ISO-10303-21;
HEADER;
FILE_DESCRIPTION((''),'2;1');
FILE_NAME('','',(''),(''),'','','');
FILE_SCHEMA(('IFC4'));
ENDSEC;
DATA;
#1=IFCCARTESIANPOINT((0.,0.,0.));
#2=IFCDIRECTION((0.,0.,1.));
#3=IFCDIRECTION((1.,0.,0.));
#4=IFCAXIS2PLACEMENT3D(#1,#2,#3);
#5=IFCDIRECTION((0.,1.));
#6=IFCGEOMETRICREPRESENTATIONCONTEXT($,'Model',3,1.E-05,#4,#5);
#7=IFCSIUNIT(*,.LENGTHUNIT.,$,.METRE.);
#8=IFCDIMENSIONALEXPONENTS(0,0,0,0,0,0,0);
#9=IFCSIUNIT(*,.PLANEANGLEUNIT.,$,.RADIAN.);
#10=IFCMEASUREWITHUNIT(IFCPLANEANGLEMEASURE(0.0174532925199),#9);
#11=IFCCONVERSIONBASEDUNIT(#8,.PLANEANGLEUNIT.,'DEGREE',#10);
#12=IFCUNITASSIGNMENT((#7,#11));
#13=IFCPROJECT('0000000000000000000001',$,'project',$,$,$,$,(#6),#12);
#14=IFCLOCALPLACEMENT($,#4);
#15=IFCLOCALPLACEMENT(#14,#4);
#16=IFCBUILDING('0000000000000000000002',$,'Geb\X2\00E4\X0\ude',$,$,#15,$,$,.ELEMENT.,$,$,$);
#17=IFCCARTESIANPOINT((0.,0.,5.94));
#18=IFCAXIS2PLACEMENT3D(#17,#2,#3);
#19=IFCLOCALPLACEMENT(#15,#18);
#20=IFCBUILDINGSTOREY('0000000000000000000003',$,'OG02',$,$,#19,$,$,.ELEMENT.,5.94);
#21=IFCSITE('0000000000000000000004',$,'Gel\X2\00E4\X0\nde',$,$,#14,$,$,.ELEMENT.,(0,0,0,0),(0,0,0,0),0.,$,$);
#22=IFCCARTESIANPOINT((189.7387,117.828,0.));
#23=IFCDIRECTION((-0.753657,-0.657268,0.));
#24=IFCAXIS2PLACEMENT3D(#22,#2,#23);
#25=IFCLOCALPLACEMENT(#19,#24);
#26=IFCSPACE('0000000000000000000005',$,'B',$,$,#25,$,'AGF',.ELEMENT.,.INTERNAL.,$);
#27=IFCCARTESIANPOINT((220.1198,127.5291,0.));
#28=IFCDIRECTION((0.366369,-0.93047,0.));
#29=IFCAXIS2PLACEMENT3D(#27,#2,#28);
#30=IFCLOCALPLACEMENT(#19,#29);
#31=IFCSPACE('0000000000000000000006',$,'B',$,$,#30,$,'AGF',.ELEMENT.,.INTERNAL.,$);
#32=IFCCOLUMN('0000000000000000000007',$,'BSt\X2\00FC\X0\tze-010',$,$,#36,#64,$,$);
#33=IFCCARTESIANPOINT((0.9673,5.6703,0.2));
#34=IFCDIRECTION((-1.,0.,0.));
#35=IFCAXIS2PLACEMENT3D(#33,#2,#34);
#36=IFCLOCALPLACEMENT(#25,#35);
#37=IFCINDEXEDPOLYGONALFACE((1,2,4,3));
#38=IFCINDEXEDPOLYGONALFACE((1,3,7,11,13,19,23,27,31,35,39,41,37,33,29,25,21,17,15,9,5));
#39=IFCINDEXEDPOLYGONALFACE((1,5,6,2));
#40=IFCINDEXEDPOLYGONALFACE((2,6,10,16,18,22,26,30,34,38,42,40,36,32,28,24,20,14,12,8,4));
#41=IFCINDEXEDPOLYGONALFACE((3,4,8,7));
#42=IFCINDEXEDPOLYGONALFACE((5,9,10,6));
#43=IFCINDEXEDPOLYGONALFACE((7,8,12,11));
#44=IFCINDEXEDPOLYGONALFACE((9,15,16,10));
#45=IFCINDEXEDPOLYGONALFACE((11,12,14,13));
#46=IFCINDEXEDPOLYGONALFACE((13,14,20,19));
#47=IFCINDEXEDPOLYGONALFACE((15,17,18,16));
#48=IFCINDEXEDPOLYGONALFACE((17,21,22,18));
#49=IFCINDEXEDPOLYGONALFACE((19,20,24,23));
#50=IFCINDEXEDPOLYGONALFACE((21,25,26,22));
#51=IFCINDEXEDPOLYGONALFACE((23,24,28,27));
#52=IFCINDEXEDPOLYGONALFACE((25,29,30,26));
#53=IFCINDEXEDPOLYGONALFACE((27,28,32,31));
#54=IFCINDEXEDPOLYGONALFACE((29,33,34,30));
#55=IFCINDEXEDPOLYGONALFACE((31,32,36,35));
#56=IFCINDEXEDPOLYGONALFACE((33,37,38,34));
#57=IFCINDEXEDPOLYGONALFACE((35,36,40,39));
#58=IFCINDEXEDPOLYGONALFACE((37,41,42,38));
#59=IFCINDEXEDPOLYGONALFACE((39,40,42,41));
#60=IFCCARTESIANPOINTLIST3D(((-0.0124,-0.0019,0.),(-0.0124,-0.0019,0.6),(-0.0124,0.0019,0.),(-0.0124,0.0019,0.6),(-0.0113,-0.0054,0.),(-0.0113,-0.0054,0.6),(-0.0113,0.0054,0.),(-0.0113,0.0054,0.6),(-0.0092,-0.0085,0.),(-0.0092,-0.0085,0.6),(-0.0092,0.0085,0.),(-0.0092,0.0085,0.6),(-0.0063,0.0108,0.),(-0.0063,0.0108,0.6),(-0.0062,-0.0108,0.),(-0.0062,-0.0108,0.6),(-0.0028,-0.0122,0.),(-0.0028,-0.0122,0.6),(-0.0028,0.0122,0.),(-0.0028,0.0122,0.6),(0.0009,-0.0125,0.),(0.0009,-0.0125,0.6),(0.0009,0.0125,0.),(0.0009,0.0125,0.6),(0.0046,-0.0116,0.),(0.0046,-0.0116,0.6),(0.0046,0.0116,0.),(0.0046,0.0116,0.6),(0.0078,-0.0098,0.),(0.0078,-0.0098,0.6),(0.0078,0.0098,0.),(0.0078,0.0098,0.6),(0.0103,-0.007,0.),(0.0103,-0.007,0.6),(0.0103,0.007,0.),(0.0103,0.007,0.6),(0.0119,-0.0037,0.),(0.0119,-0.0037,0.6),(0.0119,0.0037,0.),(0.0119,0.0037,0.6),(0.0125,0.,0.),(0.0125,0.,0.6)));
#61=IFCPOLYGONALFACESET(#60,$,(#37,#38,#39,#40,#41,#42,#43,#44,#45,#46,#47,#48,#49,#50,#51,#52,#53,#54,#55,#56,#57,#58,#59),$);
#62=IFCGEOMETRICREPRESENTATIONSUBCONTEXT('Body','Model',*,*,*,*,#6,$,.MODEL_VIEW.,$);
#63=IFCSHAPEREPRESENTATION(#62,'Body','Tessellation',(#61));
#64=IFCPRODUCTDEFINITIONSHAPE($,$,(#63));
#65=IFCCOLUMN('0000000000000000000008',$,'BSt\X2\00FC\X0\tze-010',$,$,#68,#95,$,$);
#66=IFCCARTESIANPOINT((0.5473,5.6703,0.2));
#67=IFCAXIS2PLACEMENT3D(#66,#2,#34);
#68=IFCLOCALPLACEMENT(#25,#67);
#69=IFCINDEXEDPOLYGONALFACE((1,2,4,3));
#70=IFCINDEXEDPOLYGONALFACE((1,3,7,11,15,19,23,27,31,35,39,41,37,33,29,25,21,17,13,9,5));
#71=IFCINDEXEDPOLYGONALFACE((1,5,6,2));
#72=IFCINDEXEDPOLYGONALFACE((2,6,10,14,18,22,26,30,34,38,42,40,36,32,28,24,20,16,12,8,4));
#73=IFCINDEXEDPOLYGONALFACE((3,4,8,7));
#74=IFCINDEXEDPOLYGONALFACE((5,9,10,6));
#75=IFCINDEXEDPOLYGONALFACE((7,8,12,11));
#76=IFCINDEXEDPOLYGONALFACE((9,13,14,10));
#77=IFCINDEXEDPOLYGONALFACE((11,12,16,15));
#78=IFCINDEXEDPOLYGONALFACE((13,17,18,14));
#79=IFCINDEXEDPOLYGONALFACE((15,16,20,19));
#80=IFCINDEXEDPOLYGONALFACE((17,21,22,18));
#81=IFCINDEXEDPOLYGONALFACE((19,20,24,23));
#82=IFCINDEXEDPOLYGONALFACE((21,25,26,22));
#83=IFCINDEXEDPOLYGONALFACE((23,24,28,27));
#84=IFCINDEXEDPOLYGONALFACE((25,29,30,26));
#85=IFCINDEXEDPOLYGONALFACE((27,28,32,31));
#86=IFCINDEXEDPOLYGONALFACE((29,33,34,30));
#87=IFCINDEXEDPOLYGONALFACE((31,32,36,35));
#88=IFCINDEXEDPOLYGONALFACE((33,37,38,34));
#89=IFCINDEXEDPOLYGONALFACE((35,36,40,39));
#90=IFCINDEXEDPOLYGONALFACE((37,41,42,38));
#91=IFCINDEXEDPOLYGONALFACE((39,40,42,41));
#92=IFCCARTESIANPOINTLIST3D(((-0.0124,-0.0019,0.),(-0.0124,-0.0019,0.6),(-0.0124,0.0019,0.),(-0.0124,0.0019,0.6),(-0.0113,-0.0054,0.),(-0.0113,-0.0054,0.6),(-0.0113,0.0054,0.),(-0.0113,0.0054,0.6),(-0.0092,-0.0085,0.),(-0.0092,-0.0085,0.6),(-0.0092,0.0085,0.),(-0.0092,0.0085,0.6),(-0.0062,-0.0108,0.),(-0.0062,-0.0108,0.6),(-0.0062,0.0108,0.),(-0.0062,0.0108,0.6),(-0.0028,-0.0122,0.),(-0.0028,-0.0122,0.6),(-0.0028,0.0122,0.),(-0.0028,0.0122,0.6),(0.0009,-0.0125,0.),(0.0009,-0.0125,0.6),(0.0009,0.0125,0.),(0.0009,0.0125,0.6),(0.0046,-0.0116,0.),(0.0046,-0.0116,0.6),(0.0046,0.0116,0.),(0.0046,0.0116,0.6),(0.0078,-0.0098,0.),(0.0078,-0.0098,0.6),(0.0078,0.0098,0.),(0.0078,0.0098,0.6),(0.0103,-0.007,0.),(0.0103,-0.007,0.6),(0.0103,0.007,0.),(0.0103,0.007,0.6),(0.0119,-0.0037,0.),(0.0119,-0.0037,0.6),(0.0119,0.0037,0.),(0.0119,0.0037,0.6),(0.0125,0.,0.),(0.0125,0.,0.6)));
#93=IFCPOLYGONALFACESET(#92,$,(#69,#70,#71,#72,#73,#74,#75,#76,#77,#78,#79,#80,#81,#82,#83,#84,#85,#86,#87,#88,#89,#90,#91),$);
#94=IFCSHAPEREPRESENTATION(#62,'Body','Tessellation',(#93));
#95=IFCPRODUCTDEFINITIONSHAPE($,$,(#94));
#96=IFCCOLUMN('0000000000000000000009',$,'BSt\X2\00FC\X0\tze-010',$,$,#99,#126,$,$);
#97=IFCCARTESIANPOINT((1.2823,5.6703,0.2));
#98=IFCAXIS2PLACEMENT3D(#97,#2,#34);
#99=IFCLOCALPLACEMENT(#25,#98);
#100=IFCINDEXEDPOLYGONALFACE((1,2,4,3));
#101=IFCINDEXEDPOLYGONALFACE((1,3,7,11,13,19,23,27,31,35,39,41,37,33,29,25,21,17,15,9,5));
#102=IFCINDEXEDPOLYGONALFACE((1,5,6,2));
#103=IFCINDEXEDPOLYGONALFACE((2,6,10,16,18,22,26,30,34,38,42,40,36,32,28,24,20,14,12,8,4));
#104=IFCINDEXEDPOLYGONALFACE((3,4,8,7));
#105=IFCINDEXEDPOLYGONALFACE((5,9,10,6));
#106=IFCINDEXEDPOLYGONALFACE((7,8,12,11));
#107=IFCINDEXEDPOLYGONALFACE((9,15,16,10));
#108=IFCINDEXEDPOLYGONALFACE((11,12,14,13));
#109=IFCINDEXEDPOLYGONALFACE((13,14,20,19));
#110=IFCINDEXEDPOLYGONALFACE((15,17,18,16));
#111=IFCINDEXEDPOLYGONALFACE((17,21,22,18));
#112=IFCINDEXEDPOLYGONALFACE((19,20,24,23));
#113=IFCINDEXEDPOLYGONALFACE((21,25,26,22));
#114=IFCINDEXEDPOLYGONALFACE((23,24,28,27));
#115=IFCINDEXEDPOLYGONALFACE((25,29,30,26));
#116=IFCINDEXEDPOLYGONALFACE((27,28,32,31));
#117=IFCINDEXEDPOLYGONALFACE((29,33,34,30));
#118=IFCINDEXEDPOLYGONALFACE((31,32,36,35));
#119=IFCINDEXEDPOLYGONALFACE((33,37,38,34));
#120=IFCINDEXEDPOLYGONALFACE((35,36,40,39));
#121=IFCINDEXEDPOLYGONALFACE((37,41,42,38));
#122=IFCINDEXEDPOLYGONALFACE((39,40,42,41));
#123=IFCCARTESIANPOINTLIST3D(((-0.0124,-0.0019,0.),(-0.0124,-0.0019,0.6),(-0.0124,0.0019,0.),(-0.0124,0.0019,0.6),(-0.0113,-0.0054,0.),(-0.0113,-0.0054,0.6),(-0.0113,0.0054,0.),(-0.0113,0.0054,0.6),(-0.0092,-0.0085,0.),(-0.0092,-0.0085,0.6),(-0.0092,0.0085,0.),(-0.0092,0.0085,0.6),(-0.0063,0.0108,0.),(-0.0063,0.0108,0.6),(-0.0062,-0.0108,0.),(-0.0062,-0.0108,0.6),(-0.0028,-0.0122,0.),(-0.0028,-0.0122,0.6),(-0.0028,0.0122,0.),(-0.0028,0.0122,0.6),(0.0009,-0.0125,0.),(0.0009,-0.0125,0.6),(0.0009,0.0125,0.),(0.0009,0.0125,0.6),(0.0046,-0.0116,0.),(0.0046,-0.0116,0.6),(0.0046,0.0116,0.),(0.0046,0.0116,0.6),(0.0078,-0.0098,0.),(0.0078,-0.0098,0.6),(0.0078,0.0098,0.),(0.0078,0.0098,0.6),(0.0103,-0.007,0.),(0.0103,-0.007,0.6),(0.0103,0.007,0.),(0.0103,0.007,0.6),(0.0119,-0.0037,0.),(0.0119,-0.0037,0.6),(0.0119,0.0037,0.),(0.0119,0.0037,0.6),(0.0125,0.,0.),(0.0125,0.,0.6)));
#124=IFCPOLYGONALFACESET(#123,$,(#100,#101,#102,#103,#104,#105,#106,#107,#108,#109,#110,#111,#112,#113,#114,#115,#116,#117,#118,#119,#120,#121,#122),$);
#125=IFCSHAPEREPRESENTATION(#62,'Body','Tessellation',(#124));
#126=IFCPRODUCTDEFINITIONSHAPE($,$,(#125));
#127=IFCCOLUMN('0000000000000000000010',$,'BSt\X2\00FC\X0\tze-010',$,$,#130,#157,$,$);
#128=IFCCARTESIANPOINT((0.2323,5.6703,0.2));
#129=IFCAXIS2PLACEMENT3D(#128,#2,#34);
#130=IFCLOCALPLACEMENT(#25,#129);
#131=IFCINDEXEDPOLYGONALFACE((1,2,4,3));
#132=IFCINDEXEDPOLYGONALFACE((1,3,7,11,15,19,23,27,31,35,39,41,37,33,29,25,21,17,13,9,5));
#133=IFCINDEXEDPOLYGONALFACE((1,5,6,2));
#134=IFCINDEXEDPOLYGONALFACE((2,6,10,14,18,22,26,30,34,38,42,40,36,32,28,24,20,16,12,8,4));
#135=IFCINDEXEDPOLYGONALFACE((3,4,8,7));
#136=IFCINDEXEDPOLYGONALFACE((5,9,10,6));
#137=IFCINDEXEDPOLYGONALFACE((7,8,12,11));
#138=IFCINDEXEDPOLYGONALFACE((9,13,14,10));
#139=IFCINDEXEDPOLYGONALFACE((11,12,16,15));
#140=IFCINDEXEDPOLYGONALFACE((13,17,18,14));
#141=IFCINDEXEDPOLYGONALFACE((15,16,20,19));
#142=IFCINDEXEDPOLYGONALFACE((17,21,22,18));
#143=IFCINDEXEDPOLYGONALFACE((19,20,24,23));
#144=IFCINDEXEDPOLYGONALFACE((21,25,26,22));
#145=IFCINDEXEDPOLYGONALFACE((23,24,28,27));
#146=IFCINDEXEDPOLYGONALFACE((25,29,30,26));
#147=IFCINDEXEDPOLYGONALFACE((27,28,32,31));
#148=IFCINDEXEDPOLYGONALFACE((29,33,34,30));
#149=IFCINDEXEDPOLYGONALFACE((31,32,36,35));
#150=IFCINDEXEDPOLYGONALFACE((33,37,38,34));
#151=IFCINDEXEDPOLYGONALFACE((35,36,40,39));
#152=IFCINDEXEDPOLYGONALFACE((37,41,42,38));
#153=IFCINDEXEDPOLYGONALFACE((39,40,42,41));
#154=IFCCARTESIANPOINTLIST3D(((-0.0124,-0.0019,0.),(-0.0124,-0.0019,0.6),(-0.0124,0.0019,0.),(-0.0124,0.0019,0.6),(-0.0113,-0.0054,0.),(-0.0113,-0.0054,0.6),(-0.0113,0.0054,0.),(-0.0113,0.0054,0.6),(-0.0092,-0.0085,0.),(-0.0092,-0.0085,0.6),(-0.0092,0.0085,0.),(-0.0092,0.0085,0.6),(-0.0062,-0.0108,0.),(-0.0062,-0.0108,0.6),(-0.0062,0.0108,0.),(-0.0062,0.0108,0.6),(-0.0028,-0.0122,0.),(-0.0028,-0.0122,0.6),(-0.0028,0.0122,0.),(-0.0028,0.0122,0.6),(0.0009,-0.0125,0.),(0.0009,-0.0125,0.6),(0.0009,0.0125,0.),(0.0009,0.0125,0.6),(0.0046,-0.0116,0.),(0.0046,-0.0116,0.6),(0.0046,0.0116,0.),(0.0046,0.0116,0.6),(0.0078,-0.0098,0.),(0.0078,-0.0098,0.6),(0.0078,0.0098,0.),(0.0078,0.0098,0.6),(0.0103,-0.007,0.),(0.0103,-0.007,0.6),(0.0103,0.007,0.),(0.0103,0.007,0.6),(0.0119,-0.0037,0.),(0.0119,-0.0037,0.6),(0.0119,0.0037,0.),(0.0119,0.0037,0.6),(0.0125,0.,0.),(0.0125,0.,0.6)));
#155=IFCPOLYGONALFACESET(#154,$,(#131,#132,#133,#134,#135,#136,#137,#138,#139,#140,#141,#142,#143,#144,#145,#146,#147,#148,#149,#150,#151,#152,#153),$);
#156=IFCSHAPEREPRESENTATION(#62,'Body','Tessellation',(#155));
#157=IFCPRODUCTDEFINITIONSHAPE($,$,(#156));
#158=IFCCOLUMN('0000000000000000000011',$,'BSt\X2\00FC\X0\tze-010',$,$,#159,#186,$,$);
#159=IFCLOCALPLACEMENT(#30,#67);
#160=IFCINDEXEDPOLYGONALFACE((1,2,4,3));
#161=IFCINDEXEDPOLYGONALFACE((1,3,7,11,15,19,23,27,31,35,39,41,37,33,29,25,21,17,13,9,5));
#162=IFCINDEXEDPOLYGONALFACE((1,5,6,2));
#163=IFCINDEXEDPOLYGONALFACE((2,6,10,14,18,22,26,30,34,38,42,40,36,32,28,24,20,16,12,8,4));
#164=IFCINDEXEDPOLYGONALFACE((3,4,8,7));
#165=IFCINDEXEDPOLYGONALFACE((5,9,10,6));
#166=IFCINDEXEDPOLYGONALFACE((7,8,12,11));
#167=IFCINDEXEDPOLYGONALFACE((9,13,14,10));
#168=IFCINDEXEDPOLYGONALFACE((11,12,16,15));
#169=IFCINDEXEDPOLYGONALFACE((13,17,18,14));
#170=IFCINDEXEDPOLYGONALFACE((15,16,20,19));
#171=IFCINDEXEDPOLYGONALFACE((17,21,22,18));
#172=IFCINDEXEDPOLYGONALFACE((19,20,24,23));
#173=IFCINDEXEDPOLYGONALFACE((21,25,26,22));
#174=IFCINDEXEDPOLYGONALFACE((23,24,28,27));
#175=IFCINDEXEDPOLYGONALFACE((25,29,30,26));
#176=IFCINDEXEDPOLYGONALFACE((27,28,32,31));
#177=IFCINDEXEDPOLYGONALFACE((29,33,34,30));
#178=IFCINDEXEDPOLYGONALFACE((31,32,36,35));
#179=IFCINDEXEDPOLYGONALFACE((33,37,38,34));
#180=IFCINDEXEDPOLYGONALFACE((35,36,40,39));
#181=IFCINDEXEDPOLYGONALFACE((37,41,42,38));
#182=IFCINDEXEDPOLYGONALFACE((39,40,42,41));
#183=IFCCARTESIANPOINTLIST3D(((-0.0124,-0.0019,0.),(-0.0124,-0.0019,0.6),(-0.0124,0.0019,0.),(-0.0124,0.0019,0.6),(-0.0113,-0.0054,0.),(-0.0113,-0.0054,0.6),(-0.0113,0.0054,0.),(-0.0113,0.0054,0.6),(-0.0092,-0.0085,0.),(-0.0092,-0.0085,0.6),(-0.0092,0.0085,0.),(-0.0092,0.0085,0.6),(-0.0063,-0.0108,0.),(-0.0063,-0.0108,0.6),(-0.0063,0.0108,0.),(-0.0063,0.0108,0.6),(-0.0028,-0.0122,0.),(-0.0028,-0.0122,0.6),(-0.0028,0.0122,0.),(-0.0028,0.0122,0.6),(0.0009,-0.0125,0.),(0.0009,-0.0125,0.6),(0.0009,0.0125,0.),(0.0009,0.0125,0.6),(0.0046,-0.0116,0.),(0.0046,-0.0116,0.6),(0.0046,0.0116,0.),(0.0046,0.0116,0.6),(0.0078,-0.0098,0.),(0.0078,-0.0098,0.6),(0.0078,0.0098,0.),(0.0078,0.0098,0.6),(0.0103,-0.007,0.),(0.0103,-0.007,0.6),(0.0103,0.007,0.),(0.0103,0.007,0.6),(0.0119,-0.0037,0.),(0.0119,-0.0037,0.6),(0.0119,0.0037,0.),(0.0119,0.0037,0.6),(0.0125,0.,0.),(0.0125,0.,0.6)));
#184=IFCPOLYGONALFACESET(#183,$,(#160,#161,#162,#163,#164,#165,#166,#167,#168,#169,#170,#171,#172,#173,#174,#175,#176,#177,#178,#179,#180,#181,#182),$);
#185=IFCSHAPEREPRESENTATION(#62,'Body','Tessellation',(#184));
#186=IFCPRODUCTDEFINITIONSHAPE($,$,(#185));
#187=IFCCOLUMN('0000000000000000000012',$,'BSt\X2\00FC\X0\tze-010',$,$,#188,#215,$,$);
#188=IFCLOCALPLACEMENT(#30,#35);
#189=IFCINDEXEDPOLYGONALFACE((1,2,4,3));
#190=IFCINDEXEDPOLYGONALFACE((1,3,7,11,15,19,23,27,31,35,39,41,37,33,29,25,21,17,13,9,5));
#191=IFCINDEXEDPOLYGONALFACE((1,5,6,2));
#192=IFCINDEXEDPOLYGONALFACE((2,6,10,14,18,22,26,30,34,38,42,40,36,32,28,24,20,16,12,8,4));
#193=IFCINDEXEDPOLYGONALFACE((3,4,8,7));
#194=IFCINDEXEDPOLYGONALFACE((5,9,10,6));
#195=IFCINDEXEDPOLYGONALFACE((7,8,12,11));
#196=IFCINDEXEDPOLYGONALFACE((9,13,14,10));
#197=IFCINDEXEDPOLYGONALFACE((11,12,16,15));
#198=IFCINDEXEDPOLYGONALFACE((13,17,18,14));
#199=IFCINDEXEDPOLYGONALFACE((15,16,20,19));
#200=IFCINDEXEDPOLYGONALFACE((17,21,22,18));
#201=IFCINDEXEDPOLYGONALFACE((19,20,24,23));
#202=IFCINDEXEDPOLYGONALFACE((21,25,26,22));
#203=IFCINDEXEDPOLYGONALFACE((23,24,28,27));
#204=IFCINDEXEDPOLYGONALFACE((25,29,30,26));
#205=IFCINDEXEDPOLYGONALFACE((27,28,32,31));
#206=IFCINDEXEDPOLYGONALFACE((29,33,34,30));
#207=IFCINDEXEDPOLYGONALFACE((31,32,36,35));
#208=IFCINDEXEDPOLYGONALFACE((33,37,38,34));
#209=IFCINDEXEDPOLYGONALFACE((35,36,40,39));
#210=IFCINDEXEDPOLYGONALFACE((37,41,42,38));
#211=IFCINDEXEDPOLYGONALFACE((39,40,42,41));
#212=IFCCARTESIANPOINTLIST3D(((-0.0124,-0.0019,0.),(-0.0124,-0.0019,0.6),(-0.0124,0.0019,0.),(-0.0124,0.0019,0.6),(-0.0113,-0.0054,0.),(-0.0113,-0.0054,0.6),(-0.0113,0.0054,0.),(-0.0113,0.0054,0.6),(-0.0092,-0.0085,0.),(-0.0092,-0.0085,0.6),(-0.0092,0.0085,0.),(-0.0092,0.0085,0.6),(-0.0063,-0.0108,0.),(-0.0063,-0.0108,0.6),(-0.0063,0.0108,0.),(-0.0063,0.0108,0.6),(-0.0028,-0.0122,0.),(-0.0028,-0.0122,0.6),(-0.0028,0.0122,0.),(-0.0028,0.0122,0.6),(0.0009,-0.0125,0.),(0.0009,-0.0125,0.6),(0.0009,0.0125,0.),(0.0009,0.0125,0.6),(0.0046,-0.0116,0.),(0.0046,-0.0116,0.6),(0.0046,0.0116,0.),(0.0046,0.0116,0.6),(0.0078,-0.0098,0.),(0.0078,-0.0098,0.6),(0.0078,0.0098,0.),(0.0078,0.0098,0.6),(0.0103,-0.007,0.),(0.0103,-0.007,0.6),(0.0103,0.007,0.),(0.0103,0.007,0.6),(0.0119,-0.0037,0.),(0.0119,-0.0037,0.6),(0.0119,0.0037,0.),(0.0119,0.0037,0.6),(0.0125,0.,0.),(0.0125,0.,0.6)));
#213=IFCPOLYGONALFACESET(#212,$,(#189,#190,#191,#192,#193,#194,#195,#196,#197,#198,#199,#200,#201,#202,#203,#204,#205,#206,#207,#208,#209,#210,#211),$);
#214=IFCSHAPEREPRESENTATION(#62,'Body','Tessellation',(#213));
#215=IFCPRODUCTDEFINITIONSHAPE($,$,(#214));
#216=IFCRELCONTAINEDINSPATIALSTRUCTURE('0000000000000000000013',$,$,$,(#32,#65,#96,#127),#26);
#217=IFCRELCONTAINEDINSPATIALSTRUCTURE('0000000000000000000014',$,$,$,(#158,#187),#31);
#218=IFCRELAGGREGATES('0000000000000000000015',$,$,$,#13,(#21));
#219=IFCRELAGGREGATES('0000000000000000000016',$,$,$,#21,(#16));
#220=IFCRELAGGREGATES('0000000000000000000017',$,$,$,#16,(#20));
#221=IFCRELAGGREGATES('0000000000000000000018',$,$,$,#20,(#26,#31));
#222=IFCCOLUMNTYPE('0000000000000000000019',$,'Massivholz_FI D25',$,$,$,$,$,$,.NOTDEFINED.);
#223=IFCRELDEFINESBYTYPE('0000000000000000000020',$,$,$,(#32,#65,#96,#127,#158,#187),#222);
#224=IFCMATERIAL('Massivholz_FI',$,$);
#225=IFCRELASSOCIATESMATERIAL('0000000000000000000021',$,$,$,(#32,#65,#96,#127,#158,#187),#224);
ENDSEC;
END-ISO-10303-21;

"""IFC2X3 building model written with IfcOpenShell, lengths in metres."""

from ifc_helpers import new_model, entity, si_unit, converted_unit, direction, frame, origin_with_axes, origin_2d_with_axis, place, context, subcontext, project, spatial, circle, extrude, material, type_object, element, save


model = new_model("IFC2X3")

# Units and contexts
model_context = context("Model", 3, precision=1e-05, world=origin_with_axes(), true_north=direction((0.0, 1.0)))
body_context = subcontext(model_context, "Body", "Model", "MODEL_VIEW")
ifc_project = project(units=[si_unit("LENGTHUNIT", "METRE"), converted_unit("PLANEANGLEUNIT", "DEGREE", entity("IfcPlaneAngleMeasure", 0.0174532925199), si_unit("PLANEANGLEUNIT", "RADIAN"), dimensions=[0, 0, 0, 0, 0, 0, 0])], contexts=[model_context])

# Site, building, storey, space
site_placement = place(None, origin_with_axes())
site = spatial("IfcSite", under=ifc_project, at=site_placement, Name="Gelände", CompositionType="ELEMENT", RefLatitude=(0, 0, 0, 0), RefLongitude=(0, 0, 0, 0), RefElevation=0.0)
building_placement = place(site_placement, origin_with_axes())
building = spatial("IfcBuilding", under=site, at=building_placement, Name="Gebäude", CompositionType="ELEMENT")
storey_placement = place(building_placement, frame((0.0, 0.0, 5.94), z_axis=(0.0, 0.0, 1.0), x_axis=(1.0, 0.0, 0.0)))
storey = spatial("IfcBuildingStorey", under=building, at=storey_placement, Name="OG02", CompositionType="ELEMENT", Elevation=5.94)
space_1_placement = place(storey_placement, frame((189.7387, 117.828, 0.0), z_axis=(0.0, 0.0, 1.0), x_axis=(-0.753657, -0.657268, 0.0)))
space_1 = spatial("IfcSpace", under=storey, at=space_1_placement, Name="B", LongName="AGF", CompositionType="ELEMENT", InteriorOrExteriorSpace="INTERNAL")

# Columns
ifc_material_1 = material(Name="Massivholz_FI")
column_type_1 = type_object("IfcColumnType", Name="Massivholz_FI D25", PredefinedType="NOTDEFINED")
for number, where, z_axis, x_axis, name in (
    (1, (0.9673, 5.6703, 0.2), (0.0, 0.0, 1.0), (-1.0, 0.0, 0.0), "BStütze-010"),
    (2, (0.5473, 5.6703, 0.2), (0.0, 0.0, 1.0), (-1.0, 0.0, 0.0), "BStütze-010"),
    (3, (1.2823, 5.6703, 0.2), (0.0, 0.0, 1.0), (-1.0, 0.0, 0.0), "BStütze-010"),
    (4, (0.2323, 5.6703, 0.2), (0.0, 0.0, 1.0), (-1.0, 0.0, 0.0), "BStütze-010"),
):
    element("IfcColumn", number, at=place(space_1_placement, frame(where, z_axis=z_axis, x_axis=x_axis)), inside=space_1, type_object=column_type_1, material=ifc_material_1, Name=name, context=body_context, shape_type="SweptSolid", body=[
        extrude(circle(Radius=0.0125, at=origin_2d_with_axis()), origin_with_axes(), (0.0, 0.0, 1.0), 0.6),
    ])

# Shared definitions
space_2_placement = place(storey_placement, frame((220.1198, 127.5291, 0.0), z_axis=(0.0, 0.0, 1.0), x_axis=(0.366369, -0.93047, 0.0)))
space_2 = spatial("IfcSpace", under=storey, at=space_2_placement, Name="B", LongName="AGF", CompositionType="ELEMENT", InteriorOrExteriorSpace="INTERNAL")

# Columns
for number, where, z_axis, x_axis, name in (
    (5, (0.5473, 5.6703, 0.2), (0.0, 0.0, 1.0), (-1.0, 0.0, 0.0), "BStütze-010"),
    (6, (0.9673, 5.6703, 0.2), (0.0, 0.0, 1.0), (-1.0, 0.0, 0.0), "BStütze-010"),
):
    element("IfcColumn", number, at=place(space_2_placement, frame(where, z_axis=z_axis, x_axis=x_axis)), inside=space_2, type_object=column_type_1, material=ifc_material_1, Name=name, context=body_context, shape_type="SweptSolid", body=[
        extrude(circle(Radius=0.0125, at=origin_2d_with_axis()), origin_with_axes(), (0.0, 0.0, 1.0), 0.6),
    ])

save(model, "model.ifc")
